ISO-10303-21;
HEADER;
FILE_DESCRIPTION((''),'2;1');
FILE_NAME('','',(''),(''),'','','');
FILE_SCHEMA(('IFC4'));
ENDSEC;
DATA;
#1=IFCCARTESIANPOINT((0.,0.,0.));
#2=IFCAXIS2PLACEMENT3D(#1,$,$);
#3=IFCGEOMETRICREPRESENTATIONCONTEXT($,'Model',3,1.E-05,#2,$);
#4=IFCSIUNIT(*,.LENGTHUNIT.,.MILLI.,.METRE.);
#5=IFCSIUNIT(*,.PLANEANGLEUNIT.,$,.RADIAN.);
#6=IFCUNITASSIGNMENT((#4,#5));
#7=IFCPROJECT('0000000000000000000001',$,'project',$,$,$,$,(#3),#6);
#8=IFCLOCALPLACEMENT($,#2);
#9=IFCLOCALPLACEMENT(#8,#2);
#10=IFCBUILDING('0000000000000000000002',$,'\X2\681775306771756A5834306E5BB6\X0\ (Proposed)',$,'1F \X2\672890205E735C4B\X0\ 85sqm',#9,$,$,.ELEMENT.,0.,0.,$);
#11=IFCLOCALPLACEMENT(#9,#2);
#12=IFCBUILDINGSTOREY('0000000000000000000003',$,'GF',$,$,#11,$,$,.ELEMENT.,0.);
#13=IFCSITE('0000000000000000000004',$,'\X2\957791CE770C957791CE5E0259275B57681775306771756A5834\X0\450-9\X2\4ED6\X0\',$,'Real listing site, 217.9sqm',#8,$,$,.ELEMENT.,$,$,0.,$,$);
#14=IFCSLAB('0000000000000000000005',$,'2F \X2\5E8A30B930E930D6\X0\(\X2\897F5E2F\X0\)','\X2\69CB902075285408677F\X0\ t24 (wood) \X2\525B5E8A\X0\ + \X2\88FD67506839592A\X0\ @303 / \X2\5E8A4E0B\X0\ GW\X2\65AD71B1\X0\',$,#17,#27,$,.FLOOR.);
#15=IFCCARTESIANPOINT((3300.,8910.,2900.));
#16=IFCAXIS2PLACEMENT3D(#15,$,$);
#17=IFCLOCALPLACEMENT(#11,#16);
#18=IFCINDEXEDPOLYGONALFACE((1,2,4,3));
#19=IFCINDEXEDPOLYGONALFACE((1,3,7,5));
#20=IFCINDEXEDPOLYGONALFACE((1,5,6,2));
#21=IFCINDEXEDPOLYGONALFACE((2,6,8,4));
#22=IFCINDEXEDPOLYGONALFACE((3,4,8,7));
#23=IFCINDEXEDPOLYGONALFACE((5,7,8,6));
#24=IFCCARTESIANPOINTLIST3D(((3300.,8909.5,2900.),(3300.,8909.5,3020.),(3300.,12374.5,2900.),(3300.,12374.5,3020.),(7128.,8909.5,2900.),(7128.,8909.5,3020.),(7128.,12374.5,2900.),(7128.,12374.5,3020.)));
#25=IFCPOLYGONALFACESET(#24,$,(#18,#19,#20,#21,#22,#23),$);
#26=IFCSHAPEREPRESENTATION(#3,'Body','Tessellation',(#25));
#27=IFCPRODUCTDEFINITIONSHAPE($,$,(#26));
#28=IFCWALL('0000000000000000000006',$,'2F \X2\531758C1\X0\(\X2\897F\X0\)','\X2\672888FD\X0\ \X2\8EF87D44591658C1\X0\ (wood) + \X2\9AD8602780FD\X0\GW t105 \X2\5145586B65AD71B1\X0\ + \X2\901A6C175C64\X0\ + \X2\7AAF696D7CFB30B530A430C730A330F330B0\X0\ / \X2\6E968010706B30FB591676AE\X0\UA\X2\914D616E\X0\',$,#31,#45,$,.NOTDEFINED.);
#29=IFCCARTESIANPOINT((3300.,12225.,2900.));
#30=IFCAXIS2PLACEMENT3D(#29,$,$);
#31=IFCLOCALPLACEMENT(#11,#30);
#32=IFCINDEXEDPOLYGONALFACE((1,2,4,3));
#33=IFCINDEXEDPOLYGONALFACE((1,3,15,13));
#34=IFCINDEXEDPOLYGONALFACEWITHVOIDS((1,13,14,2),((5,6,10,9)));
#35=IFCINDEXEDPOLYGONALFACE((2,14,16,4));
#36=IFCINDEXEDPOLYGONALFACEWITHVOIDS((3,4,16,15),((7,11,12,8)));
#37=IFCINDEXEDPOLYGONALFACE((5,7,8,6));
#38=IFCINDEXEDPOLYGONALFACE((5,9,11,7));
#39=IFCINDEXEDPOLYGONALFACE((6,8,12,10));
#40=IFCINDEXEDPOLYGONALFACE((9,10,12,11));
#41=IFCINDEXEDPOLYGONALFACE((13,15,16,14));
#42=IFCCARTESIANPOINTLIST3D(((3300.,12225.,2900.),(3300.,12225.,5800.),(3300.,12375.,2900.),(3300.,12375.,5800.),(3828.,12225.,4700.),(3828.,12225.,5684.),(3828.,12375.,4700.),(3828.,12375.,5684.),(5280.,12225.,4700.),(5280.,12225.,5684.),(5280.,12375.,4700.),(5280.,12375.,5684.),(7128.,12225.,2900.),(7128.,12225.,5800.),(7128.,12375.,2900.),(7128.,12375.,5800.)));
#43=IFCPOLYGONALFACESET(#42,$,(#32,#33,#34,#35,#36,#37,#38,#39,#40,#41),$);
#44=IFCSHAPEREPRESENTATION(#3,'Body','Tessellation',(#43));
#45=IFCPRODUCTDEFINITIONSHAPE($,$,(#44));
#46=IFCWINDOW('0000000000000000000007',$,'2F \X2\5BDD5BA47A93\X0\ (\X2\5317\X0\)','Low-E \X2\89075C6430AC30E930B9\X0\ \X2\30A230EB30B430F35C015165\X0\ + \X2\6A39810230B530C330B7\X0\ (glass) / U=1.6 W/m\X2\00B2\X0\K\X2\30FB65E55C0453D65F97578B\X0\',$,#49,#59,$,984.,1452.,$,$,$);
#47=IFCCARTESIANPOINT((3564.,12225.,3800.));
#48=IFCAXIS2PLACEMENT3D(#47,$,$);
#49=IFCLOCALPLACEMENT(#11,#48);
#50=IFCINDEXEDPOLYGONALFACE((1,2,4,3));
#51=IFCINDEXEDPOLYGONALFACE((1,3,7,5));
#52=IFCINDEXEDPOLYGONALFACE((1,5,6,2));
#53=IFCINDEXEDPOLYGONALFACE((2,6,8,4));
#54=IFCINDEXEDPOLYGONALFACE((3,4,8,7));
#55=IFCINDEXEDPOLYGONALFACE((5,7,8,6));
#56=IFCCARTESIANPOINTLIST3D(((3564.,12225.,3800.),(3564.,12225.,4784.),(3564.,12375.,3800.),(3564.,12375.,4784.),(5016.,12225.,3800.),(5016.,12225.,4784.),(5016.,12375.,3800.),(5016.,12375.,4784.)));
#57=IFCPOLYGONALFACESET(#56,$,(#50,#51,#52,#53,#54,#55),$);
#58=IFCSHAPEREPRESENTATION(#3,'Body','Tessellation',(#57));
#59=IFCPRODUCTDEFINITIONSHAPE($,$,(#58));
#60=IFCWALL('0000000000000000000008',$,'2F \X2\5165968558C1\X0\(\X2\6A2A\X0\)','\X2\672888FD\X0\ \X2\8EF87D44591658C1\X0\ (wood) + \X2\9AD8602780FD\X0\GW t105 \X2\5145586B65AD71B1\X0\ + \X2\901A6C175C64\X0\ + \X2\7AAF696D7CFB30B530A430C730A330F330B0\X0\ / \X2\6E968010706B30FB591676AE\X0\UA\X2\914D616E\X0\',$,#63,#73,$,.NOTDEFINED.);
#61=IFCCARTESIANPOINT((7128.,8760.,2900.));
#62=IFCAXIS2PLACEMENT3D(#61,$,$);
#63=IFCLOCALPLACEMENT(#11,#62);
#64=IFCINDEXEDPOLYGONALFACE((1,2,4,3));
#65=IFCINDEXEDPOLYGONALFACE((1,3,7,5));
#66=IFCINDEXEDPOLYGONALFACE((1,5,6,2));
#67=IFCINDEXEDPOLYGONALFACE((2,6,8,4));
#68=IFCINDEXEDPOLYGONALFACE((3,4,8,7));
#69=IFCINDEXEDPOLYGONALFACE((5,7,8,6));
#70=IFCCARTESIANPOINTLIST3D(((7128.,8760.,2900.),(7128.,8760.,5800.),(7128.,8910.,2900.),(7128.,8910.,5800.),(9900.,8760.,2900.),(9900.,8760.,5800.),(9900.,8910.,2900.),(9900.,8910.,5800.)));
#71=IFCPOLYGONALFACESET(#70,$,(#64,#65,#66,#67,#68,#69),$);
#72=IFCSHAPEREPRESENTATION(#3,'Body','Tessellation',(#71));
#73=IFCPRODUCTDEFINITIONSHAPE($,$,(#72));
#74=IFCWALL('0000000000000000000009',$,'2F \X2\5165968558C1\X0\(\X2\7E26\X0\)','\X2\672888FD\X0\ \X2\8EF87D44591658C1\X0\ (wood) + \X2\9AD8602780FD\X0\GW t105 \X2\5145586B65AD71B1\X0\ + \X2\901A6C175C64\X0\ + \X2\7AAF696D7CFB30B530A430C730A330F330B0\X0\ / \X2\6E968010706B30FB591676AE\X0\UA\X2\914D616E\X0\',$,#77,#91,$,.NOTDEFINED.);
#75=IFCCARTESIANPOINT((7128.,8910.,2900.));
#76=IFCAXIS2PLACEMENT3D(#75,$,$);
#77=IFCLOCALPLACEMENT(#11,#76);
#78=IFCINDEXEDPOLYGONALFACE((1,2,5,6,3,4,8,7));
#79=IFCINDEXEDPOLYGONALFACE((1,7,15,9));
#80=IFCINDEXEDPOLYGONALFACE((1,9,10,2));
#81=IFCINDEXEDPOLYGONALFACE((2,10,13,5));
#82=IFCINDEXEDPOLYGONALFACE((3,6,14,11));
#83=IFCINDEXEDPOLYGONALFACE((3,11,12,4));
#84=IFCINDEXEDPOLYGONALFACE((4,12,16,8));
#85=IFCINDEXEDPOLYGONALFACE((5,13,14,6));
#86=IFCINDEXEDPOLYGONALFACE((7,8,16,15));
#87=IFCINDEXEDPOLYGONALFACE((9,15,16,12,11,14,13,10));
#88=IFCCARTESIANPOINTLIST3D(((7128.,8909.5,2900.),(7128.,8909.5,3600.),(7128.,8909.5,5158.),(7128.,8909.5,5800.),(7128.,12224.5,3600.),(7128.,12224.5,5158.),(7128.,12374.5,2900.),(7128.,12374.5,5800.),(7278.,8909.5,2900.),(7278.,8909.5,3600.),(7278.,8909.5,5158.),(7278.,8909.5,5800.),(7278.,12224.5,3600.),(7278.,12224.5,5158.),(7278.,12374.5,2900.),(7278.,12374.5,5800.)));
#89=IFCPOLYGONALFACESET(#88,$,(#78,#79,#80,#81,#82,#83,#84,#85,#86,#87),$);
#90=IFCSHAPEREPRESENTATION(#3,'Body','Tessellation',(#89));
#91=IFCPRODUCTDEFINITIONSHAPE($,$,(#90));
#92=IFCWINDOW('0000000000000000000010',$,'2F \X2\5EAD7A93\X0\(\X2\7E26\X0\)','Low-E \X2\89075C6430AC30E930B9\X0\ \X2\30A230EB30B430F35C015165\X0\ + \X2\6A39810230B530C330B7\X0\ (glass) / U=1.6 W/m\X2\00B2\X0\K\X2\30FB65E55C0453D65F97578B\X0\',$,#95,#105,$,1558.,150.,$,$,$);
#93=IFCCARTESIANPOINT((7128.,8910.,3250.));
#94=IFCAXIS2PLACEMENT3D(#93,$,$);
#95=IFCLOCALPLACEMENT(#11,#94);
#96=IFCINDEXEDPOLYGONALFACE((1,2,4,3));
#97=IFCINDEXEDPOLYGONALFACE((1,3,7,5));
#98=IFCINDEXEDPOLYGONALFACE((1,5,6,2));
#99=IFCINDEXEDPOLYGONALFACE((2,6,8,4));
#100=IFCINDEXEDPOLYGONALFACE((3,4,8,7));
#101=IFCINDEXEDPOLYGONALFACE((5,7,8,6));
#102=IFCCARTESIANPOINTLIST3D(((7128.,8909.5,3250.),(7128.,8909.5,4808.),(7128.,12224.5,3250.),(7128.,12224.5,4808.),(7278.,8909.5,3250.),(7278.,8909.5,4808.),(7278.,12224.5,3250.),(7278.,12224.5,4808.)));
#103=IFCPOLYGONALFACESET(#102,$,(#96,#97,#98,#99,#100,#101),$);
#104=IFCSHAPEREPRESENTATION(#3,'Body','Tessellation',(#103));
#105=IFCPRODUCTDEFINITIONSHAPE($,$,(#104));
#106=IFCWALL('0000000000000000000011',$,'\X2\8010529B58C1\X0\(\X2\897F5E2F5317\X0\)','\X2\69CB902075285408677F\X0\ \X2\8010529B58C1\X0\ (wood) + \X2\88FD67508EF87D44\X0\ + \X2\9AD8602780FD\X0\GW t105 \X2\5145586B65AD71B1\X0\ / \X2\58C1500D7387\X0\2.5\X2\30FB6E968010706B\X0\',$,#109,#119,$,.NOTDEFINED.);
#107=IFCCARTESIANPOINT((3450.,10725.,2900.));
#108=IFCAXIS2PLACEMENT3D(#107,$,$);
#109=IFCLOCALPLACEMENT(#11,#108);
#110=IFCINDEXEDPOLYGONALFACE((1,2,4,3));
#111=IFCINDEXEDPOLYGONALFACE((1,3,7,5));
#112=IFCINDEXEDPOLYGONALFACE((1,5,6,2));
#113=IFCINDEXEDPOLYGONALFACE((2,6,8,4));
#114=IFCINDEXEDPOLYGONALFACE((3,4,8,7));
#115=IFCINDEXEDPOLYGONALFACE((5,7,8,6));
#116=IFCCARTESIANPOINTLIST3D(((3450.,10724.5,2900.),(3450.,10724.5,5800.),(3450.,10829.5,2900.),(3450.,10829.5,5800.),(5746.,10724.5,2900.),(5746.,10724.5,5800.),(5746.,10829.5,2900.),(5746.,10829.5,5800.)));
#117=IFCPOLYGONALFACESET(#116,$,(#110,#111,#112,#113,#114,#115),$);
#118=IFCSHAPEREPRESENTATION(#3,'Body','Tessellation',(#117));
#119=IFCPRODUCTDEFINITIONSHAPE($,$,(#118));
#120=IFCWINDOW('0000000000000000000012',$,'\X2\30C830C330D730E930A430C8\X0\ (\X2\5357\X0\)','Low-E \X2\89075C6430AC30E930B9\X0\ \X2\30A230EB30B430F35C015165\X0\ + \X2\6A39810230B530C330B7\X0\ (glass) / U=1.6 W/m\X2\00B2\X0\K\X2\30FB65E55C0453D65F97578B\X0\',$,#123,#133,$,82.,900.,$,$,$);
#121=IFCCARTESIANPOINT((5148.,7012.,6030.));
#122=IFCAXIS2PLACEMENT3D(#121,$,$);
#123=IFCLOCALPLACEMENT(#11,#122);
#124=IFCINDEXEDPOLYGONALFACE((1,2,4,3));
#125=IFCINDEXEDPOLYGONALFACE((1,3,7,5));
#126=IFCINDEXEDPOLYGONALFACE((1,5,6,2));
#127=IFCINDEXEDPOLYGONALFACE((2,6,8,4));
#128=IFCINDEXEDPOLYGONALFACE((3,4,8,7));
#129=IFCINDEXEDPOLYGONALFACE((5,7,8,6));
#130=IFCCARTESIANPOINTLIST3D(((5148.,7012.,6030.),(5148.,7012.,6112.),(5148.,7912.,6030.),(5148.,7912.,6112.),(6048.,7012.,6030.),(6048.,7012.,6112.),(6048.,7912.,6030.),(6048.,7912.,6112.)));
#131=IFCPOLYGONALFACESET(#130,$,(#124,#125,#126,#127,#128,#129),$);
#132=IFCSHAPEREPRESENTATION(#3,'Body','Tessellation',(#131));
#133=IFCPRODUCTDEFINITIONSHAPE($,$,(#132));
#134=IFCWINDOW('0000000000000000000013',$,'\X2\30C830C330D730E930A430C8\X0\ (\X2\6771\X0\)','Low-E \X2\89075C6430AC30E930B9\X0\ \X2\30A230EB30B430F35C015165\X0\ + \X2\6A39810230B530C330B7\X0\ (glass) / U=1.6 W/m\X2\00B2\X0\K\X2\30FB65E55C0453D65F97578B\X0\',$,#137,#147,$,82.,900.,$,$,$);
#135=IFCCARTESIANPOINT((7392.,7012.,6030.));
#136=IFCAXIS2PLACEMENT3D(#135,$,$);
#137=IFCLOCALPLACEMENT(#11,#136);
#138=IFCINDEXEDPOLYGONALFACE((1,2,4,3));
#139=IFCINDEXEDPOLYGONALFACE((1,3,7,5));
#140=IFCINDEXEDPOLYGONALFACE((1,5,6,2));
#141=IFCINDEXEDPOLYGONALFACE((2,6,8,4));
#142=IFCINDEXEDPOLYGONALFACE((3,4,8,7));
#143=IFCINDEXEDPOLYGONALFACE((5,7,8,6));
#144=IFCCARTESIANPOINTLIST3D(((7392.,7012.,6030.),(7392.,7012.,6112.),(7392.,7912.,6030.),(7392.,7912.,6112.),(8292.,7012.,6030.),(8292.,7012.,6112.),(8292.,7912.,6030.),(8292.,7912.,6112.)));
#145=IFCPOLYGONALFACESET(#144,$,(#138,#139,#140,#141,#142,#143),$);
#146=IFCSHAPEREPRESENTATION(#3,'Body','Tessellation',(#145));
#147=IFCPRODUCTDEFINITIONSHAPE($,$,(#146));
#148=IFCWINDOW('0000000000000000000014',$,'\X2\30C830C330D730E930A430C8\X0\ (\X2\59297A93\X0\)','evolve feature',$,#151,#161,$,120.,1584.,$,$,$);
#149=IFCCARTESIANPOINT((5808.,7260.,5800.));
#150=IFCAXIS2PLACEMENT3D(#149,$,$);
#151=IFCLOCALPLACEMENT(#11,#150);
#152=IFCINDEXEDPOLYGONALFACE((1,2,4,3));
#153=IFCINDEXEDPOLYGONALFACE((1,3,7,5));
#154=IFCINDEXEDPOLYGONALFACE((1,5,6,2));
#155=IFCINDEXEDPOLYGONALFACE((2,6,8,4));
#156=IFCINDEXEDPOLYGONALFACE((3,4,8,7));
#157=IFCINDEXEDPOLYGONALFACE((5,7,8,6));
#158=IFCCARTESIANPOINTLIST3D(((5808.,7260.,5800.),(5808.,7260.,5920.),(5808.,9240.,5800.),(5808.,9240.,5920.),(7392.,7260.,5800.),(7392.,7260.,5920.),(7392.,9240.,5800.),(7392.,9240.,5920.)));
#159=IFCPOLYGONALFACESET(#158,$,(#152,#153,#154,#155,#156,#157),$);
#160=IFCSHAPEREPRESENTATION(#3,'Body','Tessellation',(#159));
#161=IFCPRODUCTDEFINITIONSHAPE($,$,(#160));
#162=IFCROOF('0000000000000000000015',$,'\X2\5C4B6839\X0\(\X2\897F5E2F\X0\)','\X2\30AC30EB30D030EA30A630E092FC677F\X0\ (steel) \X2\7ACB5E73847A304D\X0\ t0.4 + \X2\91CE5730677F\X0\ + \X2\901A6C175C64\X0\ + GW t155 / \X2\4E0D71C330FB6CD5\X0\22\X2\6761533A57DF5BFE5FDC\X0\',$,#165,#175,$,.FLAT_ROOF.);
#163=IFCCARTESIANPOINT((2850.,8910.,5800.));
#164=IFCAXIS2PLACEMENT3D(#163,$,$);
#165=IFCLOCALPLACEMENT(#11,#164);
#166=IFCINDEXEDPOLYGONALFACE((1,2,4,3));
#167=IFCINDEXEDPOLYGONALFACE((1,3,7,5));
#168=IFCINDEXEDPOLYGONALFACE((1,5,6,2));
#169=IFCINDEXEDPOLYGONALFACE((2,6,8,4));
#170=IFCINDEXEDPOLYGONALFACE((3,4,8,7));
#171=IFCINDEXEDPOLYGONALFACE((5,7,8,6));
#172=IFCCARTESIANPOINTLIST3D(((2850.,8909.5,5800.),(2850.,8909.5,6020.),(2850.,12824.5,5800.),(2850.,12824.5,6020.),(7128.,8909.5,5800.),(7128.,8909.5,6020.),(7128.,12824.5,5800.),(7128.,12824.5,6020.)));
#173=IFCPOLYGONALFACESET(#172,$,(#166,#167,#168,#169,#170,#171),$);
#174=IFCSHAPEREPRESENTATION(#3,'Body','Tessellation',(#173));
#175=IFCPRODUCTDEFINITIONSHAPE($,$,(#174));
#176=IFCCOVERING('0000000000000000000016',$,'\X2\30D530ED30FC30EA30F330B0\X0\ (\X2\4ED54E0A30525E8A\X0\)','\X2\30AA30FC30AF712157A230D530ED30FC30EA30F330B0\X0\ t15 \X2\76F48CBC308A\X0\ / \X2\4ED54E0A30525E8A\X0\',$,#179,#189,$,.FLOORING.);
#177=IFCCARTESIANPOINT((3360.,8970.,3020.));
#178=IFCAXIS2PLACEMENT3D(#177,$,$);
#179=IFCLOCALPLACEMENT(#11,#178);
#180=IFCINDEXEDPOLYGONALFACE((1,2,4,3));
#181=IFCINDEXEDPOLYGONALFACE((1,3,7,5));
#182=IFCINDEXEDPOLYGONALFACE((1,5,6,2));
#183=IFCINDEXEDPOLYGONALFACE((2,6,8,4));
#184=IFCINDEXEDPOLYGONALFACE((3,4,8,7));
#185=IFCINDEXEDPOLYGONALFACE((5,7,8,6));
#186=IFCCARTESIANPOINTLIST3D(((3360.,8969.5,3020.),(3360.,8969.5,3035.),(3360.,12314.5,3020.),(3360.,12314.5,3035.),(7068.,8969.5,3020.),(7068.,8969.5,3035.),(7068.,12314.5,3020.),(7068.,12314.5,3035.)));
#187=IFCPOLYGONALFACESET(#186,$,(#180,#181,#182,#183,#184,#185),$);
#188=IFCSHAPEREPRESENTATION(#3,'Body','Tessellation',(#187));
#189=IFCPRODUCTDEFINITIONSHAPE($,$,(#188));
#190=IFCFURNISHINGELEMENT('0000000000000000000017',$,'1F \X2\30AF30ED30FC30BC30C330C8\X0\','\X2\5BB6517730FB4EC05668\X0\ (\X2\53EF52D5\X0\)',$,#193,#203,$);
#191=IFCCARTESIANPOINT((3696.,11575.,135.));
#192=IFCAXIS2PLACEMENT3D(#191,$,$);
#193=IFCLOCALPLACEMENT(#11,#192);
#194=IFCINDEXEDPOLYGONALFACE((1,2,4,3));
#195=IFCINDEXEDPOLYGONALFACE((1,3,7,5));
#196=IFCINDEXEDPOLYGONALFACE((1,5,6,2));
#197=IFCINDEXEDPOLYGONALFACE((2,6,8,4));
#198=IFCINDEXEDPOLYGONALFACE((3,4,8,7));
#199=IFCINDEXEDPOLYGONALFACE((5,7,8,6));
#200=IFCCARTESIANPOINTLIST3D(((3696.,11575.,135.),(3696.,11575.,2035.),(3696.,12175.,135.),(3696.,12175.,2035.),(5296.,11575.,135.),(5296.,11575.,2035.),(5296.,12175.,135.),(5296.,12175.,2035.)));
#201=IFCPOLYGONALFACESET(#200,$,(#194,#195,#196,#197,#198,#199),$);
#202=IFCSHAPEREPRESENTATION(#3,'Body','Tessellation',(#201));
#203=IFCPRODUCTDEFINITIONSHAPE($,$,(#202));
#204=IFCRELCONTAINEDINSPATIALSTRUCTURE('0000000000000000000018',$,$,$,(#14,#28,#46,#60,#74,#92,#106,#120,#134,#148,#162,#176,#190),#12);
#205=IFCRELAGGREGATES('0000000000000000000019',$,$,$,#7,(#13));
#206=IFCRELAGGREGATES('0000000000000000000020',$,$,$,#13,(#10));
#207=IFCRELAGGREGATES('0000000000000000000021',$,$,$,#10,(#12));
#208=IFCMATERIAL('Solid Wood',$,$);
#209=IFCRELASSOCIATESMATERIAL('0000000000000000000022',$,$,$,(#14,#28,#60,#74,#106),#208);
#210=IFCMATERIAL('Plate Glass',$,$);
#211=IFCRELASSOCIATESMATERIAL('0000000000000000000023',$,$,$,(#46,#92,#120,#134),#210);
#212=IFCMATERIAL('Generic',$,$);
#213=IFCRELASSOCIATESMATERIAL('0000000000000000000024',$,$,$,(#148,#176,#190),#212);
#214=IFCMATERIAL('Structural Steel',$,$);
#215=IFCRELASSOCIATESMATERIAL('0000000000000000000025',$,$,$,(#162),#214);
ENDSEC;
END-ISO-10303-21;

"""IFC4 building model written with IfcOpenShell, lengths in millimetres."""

from ifc_helpers import new_model, si_unit, frame, frame_2d, origin, place, context, project, spatial, rectangle, extrude, material, element, fill, save


model = new_model("IFC4")

# Units and contexts
model_context = context("Model", 3, precision=1e-05, world=origin())
ifc_project = project(units=[si_unit("LENGTHUNIT", "METRE", prefix="MILLI"), si_unit("PLANEANGLEUNIT", "RADIAN")], contexts=[model_context])

# Site, building, storey
site_placement = place(None, origin())
site = spatial("IfcSite", under=ifc_project, at=site_placement, Name="長野県長野市大字栗田東番場450-9他", ObjectType="Real listing site, 217.9sqm", CompositionType="ELEMENT", RefElevation=0.0)
building_placement = place(site_placement, origin())
building = spatial("IfcBuilding", under=site, at=building_placement, Name="栗田東番場の家 (Proposed)", ObjectType="1F 木造平屋 85sqm", CompositionType="ELEMENT", ElevationOfRefHeight=0.0, ElevationOfTerrain=0.0)
storey_placement = place(building_placement, origin())
storey = spatial("IfcBuildingStorey", under=building, at=storey_placement, Name="GF", CompositionType="ELEMENT", Elevation=0.0)

# Slab
ifc_material_1 = material(Name="Solid Wood")
slab_placement = place(storey_placement, frame((3300.0, 8910.0, 2900.0)))
element("IfcSlab", 1, at=slab_placement, inside=storey, material=ifc_material_1, Name="2F 床スラブ(西帯)", Description="構造用合板 t24 (wood) 剛床 + 製材根太 @303 / 床下 GW断熱", PredefinedType="FLOOR", context=model_context, shape_type="SweptSolid", body=[
    extrude(rectangle(XDim=3828.0, YDim=3465.0, at=frame_2d((1914.0, 1732.0))), frame((3300.0, 8910.0, 2900.0)), (0.0, 0.0, 1.0), 120.0),
])

# Wall, opening, window
wall_1_placement = place(storey_placement, frame((3300.0, 12225.0, 2900.0)))
wall_1 = element("IfcWall", 2, at=wall_1_placement, inside=storey, material=ifc_material_1, Name="2F 北壁(西)", Description="木製 軸組外壁 (wood) + 高性能GW t105 充填断熱 + 通気層 + 窯業系サイディング / 準耐火・外皮UA配慮", PredefinedType="NOTDEFINED", context=model_context, shape_type="SweptSolid", body=[
    extrude(rectangle(XDim=3828.0, YDim=150.0, at=frame_2d((1914.0, 75.0))), frame((3300.0, 12225.0, 2900.0)), (0.0, 0.0, 1.0), 2900.0),
])
opening_1_placement = place(storey_placement, frame((3564.0, 12225.0, 3800.0)))
opening_1 = element("IfcOpeningElement", 3, at=opening_1_placement, cuts=wall_1, PredefinedType="NOTDEFINED", context=model_context, shape_type="SweptSolid", body=[
    extrude(rectangle(XDim=1452.0, YDim=150.0, at=frame_2d((726.0, 75.0))), frame((3564.0, 12225.0, 3800.0)), (0.0, 0.0, 1.0), 984.0),
])
ifc_material_2 = material(Name="Plate Glass")
window_1_placement = place(storey_placement, frame((3564.0, 12225.0, 3800.0)))
window_1 = element("IfcWindow", 4, at=window_1_placement, inside=storey, material=ifc_material_2, Name="2F 寝室窓 (北)", Description="Low-E 複層ガラス アルゴン封入 + 樹脂サッシ (glass) / U=1.6 W/m²K・日射取得型", OverallHeight=984.0, OverallWidth=1452.0, context=model_context, shape_type="SweptSolid", body=[
    extrude(rectangle(XDim=1452.0, YDim=150.0, at=frame_2d((726.0, 75.0))), frame((3564.0, 12225.0, 3800.0)), (0.0, 0.0, 1.0), 984.0),
])
fill(opening_1, window_1)

# Wall
wall_2_placement = place(storey_placement, frame((7128.0, 8760.0, 2900.0)))
element("IfcWall", 5, at=wall_2_placement, inside=storey, material=ifc_material_1, Name="2F 入隅壁(横)", Description="木製 軸組外壁 (wood) + 高性能GW t105 充填断熱 + 通気層 + 窯業系サイディング / 準耐火・外皮UA配慮", PredefinedType="NOTDEFINED", context=model_context, shape_type="SweptSolid", body=[
    extrude(rectangle(XDim=2772.0, YDim=150.0, at=frame_2d((1386.0, 75.0))), frame((7128.0, 8760.0, 2900.0)), (0.0, 0.0, 1.0), 2900.0),
])

# Wall, opening, window
wall_3_placement = place(storey_placement, frame((7128.0, 8910.0, 2900.0)))
wall_3 = element("IfcWall", 6, at=wall_3_placement, inside=storey, material=ifc_material_1, Name="2F 入隅壁(縦)", Description="木製 軸組外壁 (wood) + 高性能GW t105 充填断熱 + 通気層 + 窯業系サイディング / 準耐火・外皮UA配慮", PredefinedType="NOTDEFINED", context=model_context, shape_type="SweptSolid", body=[
    extrude(rectangle(XDim=150.0, YDim=3465.0, at=frame_2d((75.0, 1732.0))), frame((7128.0, 8910.0, 2900.0)), (0.0, 0.0, 1.0), 2900.0),
])
opening_2_placement = place(storey_placement, frame((7128.0, 8910.0, 3250.0)))
opening_2 = element("IfcOpeningElement", 7, at=opening_2_placement, cuts=wall_3, PredefinedType="NOTDEFINED", context=model_context, shape_type="SweptSolid", body=[
    extrude(rectangle(XDim=150.0, YDim=3315.0, at=frame_2d((75.0, 1657.0))), frame((7128.0, 8910.0, 3250.0)), (0.0, 0.0, 1.0), 1558.0),
])
window_2_placement = place(storey_placement, frame((7128.0, 8910.0, 3250.0)))
window_2 = element("IfcWindow", 8, at=window_2_placement, inside=storey, material=ifc_material_2, Name="2F 庭窓(縦)", Description="Low-E 複層ガラス アルゴン封入 + 樹脂サッシ (glass) / U=1.6 W/m²K・日射取得型", OverallHeight=1558.0, OverallWidth=150.0, context=model_context, shape_type="SweptSolid", body=[
    extrude(rectangle(XDim=150.0, YDim=3315.0, at=frame_2d((75.0, 1657.0))), frame((7128.0, 8910.0, 3250.0)), (0.0, 0.0, 1.0), 1558.0),
])
fill(opening_2, window_2)

# Wall
wall_4_placement = place(storey_placement, frame((3450.0, 10725.0, 2900.0)))
element("IfcWall", 9, at=wall_4_placement, inside=storey, material=ifc_material_1, Name="耐力壁(西帯北)", Description="構造用合板 耐力壁 (wood) + 製材軸組 + 高性能GW t105 充填断熱 / 壁倍率2.5・準耐火", PredefinedType="NOTDEFINED", context=model_context, shape_type="SweptSolid", body=[
    extrude(rectangle(XDim=2296.0, YDim=105.0, at=frame_2d((1148.0, 52.0))), frame((3450.0, 10725.0, 2900.0)), (0.0, 0.0, 1.0), 2900.0),
])

# Windows
window_3_placement = place(storey_placement, frame((5148.0, 7012.0, 6030.0)))
element("IfcWindow", 10, at=window_3_placement, inside=storey, material=ifc_material_2, Name="トップライト (南)", Description="Low-E 複層ガラス アルゴン封入 + 樹脂サッシ (glass) / U=1.6 W/m²K・日射取得型", OverallHeight=82.0, OverallWidth=900.0, context=model_context, shape_type="SweptSolid", body=[
    extrude(rectangle(XDim=900.0, YDim=900.0, at=frame_2d((450.0, 450.0))), frame((5148.0, 7012.0, 6030.0)), (0.0, 0.0, 1.0), 82.0),
])
window_4_placement = place(storey_placement, frame((7392.0, 7012.0, 6030.0)))
element("IfcWindow", 11, at=window_4_placement, inside=storey, material=ifc_material_2, Name="トップライト (東)", Description="Low-E 複層ガラス アルゴン封入 + 樹脂サッシ (glass) / U=1.6 W/m²K・日射取得型", OverallHeight=82.0, OverallWidth=900.0, context=model_context, shape_type="SweptSolid", body=[
    extrude(rectangle(XDim=900.0, YDim=900.0, at=frame_2d((450.0, 450.0))), frame((7392.0, 7012.0, 6030.0)), (0.0, 0.0, 1.0), 82.0),
])
ifc_material_3 = material(Name="Generic")
window_5_placement = place(storey_placement, frame((5808.0, 7260.0, 5800.0)))
element("IfcWindow", 12, at=window_5_placement, inside=storey, material=ifc_material_3, Name="トップライト (天窓)", Description="evolve feature", OverallHeight=120.0, OverallWidth=1584.0, context=model_context, shape_type="SweptSolid", body=[
    extrude(rectangle(XDim=1584.0, YDim=1980.0, at=frame_2d((792.0, 990.0))), frame((5808.0, 7260.0, 5800.0)), (0.0, 0.0, 1.0), 120.0),
])

# Roof
ifc_material_4 = material(Name="Structural Steel")
for number, where, name in (
    (13, (2850.0, 8910.0, 5800.0), "屋根(西帯)"),
):
    element("IfcRoof", number, at=place(storey_placement, frame(where)), inside=storey, material=ifc_material_4, Name=name, Description="ガルバリウム鋼板 (steel) 立平葺き t0.4 + 野地板 + 通気層 + GW t155 / 不燃・法22条区域対応", PredefinedType="FLAT_ROOF", context=model_context, shape_type="SweptSolid", body=[
        extrude(rectangle(XDim=4278.0, YDim=3915.0, at=frame_2d((2139.0, 1957.0))), frame((2850.0, 8910.0, 5800.0)), (0.0, 0.0, 1.0), 220.0),
    ])

# Covering
covering_placement = place(storey_placement, frame((3360.0, 8970.0, 3020.0)))
element("IfcCovering", 14, at=covering_placement, inside=storey, material=ifc_material_3, Name="フローリング (仕上げ床)", Description="オーク無垢フローリング t15 直貼り / 仕上げ床", PredefinedType="FLOORING", context=model_context, shape_type="SweptSolid", body=[
    extrude(rectangle(XDim=3708.0, YDim=3345.0, at=frame_2d((1854.0, 1672.0))), frame((3360.0, 8970.0, 3020.0)), (0.0, 0.0, 1.0), 15.0),
])

# Furnishing element
furnishing_1_placement = place(storey_placement, frame((3696.0, 11575.0, 135.0)))
element("IfcFurnishingElement", 15, at=furnishing_1_placement, inside=storey, material=ifc_material_3, Name="1F クローゼット", Description="家具・什器 (可動)", context=model_context, shape_type="SweptSolid", body=[
    extrude(rectangle(XDim=1600.0, YDim=600.0, at=frame_2d((800.0, 300.0))), frame((3696.0, 11575.0, 135.0)), (0.0, 0.0, 1.0), 1900.0),
])

save(model, "model.ifc")
